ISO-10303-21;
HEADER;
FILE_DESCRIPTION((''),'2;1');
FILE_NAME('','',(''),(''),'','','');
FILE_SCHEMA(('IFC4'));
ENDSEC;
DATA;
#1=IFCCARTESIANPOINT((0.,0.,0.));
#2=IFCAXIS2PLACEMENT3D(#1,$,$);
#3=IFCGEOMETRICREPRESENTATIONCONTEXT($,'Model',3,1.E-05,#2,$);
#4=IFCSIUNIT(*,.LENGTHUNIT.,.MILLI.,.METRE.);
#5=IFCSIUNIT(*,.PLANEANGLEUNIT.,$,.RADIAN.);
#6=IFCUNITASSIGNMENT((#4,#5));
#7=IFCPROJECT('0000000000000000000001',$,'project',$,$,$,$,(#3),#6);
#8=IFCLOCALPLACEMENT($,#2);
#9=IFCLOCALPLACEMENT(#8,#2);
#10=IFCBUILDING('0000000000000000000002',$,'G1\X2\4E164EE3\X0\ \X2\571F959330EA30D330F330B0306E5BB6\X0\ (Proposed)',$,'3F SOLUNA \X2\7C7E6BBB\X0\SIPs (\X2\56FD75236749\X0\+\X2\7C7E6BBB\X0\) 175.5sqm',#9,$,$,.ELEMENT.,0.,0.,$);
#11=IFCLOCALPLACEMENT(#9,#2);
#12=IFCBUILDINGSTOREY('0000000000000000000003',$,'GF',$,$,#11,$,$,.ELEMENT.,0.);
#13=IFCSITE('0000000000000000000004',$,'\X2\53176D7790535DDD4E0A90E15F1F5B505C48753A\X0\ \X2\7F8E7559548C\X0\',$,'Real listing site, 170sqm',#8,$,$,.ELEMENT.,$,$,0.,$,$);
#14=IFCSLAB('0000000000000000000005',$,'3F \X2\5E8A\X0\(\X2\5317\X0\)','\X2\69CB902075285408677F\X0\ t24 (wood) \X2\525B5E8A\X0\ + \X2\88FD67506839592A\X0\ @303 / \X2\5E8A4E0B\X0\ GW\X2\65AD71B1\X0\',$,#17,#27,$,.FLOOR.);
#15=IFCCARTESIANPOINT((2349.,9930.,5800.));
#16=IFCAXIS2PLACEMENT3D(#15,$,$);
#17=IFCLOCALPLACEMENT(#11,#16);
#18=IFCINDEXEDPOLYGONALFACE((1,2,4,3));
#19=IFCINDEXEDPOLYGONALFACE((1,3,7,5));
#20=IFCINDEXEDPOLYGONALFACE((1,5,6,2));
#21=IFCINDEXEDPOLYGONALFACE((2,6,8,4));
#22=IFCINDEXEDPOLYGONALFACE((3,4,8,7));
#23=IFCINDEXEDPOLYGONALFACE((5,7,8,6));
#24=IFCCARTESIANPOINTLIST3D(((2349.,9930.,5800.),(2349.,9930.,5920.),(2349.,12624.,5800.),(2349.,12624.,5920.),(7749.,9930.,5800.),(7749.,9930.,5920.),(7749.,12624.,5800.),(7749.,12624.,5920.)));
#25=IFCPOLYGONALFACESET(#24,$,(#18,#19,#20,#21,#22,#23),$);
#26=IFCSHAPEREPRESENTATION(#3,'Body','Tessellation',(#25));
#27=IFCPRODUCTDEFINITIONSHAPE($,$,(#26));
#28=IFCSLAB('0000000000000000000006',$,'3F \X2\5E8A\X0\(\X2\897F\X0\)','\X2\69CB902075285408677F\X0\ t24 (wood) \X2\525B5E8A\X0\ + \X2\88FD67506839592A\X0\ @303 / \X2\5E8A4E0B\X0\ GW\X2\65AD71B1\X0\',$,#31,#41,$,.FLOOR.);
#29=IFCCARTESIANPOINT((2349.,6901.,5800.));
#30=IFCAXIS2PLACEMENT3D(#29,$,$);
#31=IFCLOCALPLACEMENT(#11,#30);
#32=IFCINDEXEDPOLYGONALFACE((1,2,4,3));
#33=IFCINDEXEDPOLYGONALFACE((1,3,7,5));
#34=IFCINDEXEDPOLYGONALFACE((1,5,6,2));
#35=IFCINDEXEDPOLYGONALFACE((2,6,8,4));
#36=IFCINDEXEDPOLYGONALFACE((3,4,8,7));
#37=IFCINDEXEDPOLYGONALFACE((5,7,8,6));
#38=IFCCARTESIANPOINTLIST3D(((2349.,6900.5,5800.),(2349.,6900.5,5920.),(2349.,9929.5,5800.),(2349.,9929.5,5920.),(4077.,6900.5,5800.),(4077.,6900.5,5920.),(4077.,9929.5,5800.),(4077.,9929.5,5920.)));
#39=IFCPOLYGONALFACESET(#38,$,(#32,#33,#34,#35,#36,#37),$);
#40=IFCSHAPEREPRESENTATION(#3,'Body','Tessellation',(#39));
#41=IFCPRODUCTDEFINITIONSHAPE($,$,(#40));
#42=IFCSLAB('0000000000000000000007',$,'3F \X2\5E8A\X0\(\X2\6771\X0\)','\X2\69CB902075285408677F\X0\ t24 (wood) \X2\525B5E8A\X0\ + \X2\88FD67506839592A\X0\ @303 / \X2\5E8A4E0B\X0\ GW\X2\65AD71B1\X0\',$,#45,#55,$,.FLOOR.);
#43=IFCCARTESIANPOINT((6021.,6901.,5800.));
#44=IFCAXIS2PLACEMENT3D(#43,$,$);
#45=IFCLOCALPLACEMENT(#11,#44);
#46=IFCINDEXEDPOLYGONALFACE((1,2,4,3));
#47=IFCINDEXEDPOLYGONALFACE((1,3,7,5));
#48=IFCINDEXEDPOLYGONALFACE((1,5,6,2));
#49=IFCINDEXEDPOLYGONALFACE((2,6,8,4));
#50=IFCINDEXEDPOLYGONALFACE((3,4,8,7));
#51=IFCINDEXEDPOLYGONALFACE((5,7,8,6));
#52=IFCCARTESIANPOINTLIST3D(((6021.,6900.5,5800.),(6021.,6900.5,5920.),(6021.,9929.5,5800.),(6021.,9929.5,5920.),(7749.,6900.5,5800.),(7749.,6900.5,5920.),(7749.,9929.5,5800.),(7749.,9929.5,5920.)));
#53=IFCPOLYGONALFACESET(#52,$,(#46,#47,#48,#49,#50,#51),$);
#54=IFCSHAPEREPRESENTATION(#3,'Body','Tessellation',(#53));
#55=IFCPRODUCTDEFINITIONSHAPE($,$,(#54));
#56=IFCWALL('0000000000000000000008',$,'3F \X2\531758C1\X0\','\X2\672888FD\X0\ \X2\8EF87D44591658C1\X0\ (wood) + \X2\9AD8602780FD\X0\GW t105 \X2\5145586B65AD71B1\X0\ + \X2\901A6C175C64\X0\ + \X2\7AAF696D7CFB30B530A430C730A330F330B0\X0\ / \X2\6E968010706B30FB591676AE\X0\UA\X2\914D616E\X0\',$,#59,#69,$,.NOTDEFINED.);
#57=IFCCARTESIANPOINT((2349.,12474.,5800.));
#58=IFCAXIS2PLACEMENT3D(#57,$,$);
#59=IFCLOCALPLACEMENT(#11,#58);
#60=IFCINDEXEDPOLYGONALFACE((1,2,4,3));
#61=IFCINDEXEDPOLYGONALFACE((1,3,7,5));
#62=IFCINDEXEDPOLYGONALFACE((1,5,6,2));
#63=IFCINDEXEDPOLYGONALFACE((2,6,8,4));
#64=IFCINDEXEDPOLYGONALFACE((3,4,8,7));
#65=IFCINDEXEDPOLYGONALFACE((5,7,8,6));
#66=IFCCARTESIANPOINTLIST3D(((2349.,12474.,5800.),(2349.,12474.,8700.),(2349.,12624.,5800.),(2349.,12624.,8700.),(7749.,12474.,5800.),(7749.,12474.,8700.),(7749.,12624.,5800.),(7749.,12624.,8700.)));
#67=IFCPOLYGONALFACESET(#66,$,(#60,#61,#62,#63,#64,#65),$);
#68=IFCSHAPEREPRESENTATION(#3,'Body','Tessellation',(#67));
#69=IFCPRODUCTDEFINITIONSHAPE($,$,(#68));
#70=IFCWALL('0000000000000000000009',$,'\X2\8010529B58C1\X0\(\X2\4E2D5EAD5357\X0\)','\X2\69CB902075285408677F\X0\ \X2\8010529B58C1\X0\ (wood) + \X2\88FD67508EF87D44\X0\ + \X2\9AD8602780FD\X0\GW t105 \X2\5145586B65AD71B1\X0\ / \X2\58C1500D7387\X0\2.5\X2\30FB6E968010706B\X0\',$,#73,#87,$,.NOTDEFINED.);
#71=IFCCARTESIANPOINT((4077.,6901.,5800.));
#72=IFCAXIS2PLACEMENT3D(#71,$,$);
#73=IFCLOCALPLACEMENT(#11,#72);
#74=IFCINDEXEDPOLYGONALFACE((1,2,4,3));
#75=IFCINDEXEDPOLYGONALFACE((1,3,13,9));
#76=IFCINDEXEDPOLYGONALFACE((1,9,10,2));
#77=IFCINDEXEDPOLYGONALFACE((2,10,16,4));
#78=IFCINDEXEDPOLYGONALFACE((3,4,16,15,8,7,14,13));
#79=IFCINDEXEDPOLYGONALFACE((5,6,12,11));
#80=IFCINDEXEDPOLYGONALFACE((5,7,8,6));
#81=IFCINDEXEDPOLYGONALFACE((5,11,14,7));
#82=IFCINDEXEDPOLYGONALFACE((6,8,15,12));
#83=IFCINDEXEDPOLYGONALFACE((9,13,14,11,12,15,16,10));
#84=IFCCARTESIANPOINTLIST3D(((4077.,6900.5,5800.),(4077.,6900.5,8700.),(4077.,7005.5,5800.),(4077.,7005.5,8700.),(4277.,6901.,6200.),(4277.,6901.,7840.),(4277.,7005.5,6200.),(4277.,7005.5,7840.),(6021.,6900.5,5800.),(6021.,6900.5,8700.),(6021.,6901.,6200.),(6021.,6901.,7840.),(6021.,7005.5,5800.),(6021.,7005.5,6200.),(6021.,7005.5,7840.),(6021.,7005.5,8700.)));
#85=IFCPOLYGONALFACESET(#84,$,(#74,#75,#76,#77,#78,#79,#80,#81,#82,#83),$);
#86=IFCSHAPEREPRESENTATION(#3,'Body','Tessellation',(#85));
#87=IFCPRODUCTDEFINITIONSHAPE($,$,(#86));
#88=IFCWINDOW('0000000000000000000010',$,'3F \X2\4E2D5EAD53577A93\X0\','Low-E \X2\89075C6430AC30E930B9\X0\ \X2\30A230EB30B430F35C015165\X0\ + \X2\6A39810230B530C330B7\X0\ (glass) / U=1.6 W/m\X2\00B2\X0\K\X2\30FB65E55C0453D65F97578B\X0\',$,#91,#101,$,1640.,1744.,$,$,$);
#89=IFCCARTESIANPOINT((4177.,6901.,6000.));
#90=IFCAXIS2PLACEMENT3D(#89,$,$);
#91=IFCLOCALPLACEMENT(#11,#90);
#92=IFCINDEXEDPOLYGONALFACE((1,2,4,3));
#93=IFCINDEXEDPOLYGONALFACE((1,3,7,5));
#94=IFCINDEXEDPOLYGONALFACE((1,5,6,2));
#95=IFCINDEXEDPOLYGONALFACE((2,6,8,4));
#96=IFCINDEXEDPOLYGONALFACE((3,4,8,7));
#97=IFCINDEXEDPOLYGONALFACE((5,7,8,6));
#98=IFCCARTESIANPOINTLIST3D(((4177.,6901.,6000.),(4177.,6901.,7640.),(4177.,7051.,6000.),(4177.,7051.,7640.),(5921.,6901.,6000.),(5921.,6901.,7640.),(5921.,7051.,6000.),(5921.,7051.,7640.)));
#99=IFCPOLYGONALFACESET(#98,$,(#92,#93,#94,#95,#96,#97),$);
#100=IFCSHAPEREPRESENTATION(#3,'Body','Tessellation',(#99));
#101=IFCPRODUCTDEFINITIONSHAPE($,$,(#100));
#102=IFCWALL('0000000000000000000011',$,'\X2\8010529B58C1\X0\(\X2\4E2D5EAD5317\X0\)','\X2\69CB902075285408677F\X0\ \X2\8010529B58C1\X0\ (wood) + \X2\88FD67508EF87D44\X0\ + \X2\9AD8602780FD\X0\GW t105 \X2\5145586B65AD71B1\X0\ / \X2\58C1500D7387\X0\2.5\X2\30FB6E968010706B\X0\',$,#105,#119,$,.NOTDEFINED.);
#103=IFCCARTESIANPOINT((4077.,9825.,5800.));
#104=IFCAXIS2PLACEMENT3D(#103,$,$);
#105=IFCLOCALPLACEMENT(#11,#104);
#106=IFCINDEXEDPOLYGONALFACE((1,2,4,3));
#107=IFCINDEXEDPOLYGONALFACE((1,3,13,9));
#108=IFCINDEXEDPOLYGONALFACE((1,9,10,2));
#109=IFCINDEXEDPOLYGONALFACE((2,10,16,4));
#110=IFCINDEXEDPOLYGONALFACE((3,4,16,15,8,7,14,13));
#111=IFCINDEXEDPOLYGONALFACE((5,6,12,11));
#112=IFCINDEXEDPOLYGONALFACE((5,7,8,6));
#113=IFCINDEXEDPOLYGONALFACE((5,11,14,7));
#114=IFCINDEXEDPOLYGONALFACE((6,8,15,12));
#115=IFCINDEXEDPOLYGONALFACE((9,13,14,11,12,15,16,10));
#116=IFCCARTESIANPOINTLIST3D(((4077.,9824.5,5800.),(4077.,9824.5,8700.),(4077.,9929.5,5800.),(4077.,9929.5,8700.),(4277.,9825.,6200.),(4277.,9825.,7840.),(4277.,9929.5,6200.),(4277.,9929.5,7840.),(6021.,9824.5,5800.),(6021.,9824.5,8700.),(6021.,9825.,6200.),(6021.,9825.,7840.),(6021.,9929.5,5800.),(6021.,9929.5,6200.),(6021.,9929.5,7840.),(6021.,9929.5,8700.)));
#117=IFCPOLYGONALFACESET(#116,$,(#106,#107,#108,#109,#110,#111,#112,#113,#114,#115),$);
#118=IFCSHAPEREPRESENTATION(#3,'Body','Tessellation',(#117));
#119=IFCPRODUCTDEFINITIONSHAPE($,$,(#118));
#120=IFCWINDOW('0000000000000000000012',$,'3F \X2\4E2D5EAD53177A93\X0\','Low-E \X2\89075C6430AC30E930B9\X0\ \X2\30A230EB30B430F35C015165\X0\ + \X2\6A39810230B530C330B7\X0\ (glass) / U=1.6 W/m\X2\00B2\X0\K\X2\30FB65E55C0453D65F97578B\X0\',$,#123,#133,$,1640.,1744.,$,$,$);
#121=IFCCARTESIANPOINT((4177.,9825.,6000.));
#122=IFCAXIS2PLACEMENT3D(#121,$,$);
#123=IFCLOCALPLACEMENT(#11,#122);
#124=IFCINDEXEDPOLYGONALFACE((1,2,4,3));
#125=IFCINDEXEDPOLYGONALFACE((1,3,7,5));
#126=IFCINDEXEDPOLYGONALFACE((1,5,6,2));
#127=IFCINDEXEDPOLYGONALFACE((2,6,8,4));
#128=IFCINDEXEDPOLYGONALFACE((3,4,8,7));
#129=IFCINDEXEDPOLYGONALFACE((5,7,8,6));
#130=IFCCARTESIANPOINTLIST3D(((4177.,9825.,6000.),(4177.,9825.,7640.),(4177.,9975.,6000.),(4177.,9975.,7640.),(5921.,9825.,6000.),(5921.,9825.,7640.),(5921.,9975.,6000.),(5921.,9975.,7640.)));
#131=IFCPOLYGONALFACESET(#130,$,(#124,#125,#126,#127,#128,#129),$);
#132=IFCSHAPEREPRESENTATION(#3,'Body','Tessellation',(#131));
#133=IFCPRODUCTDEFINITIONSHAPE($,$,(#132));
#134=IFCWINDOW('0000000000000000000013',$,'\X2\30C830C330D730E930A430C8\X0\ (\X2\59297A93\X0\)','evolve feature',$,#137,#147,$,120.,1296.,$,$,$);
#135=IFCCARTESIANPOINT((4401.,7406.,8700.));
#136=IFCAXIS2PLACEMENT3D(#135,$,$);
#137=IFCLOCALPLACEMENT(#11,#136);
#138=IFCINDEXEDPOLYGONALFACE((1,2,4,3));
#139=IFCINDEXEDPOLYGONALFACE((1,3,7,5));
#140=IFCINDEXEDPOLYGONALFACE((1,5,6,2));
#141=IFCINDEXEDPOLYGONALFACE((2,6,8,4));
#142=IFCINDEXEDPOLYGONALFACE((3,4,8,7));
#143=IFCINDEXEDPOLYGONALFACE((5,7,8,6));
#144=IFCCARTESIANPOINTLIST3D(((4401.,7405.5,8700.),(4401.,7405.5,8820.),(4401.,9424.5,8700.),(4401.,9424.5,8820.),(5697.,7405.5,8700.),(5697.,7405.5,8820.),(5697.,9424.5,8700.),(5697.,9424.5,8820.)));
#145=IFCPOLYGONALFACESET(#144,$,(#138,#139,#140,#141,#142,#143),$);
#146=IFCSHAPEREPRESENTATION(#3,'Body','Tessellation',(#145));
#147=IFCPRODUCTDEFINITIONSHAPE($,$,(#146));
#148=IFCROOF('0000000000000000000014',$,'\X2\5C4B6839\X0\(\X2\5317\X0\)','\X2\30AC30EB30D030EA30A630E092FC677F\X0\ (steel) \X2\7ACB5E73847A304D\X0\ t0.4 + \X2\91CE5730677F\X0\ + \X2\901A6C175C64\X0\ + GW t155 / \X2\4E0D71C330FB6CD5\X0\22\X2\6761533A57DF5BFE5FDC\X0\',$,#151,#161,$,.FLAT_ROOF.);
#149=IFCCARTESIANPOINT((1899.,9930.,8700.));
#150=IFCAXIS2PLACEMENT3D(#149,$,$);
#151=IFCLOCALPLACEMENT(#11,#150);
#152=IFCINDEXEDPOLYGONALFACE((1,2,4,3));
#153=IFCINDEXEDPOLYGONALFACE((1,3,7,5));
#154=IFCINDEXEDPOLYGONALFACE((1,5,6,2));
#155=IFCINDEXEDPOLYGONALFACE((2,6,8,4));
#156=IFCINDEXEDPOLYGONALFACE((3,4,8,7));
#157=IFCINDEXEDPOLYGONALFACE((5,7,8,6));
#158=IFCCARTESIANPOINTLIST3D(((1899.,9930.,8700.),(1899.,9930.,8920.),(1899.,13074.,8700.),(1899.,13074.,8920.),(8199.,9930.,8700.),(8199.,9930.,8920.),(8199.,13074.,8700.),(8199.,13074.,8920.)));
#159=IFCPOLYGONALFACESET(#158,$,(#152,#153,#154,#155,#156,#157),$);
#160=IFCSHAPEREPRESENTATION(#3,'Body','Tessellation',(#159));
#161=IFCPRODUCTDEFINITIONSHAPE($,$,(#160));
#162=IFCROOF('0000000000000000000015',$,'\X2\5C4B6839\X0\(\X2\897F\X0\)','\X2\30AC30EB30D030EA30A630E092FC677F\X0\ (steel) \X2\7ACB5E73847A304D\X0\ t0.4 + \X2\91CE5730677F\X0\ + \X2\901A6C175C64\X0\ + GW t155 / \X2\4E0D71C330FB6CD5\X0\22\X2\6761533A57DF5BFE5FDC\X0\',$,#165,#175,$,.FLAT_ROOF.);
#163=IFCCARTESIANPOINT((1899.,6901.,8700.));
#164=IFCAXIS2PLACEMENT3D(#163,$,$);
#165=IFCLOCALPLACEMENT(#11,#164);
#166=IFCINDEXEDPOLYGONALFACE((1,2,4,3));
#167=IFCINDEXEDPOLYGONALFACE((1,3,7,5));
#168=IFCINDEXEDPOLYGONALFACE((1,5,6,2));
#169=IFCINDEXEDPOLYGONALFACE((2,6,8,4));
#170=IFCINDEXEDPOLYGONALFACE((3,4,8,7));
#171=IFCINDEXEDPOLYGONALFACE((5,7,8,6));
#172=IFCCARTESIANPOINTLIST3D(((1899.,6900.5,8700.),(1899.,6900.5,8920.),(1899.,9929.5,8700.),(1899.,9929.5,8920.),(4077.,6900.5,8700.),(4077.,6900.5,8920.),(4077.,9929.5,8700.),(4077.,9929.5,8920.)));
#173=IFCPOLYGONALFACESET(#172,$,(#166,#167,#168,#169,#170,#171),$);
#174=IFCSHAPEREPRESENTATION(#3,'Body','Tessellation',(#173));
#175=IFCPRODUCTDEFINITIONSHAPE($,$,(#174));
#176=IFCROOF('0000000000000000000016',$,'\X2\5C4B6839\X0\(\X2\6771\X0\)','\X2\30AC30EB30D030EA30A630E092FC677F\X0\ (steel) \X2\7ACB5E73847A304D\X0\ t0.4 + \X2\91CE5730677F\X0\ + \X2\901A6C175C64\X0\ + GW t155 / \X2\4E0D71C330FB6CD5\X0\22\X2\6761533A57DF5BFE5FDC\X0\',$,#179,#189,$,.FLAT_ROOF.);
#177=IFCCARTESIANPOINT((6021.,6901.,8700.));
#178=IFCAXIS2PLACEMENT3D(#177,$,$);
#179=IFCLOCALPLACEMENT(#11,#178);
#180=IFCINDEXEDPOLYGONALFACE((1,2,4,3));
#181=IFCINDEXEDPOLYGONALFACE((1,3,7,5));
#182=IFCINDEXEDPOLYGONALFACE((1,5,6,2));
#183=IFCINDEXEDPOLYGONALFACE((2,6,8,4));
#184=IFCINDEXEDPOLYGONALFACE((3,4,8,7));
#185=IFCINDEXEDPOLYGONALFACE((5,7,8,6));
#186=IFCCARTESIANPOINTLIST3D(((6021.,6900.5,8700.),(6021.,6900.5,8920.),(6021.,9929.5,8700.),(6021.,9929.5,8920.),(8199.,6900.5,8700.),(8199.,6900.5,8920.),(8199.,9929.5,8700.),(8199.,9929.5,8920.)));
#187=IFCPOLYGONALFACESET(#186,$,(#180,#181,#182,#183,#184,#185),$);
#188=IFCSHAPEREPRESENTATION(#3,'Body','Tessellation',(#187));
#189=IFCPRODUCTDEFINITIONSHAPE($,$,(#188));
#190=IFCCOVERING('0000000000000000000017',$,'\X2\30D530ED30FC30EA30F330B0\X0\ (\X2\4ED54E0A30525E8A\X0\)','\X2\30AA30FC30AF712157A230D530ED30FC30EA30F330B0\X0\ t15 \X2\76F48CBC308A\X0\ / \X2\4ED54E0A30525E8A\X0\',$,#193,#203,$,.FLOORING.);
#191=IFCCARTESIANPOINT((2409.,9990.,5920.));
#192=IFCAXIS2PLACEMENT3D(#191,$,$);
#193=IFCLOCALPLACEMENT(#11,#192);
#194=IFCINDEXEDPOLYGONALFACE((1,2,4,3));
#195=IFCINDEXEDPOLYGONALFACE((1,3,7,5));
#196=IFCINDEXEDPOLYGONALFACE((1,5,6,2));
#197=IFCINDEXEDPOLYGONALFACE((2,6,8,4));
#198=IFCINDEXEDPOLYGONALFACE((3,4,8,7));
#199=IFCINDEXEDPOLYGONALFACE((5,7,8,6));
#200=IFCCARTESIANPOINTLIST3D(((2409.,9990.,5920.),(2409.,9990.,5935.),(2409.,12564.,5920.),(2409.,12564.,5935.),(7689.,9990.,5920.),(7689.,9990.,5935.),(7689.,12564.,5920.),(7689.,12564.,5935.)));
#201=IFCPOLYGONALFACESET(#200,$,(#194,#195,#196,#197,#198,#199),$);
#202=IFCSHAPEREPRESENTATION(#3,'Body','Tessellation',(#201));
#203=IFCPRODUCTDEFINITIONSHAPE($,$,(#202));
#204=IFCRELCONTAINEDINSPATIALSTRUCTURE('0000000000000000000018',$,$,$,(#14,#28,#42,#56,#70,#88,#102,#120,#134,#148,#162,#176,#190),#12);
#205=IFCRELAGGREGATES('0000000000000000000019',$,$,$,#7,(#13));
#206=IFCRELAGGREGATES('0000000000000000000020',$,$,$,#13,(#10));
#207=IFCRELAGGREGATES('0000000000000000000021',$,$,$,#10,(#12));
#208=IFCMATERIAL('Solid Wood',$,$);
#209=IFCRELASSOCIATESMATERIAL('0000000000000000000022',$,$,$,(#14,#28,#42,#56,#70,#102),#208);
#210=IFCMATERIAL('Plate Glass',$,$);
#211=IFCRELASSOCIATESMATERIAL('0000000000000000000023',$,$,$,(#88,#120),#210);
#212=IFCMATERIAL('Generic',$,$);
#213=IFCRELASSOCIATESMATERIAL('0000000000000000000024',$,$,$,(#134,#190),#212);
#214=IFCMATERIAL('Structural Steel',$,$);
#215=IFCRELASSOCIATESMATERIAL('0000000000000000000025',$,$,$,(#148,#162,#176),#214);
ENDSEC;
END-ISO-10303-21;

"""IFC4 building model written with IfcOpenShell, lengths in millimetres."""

from ifc_helpers import new_model, si_unit, frame, frame_2d, origin, place, context, project, spatial, rectangle, extrude, material, element, fill, save


model = new_model("IFC4")

# Units and contexts
model_context = context("Model", 3, precision=1e-05, world=origin())
ifc_project = project(units=[si_unit("LENGTHUNIT", "METRE", prefix="MILLI"), si_unit("PLANEANGLEUNIT", "RADIAN")], contexts=[model_context])

# Site, building, storey
site_placement = place(None, origin())
site = spatial("IfcSite", under=ifc_project, at=site_placement, Name="北海道川上郡弟子屈町 美留和", ObjectType="Real listing site, 170sqm", CompositionType="ELEMENT", RefElevation=0.0)
building_placement = place(site_placement, origin())
building = spatial("IfcBuilding", under=site, at=building_placement, Name="G1世代 土間リビングの家 (Proposed)", ObjectType="3F SOLUNA 籾殻SIPs (国産杉+籾殻) 175.5sqm", CompositionType="ELEMENT", ElevationOfRefHeight=0.0, ElevationOfTerrain=0.0)
storey_placement = place(building_placement, origin())
storey = spatial("IfcBuildingStorey", under=building, at=storey_placement, Name="GF", CompositionType="ELEMENT", Elevation=0.0)

# Slabs
ifc_material_1 = material(Name="Solid Wood")
slab_1_placement = place(storey_placement, frame((2349.0, 9930.0, 5800.0)))
element("IfcSlab", 1, at=slab_1_placement, inside=storey, material=ifc_material_1, Name="3F 床(北)", Description="構造用合板 t24 (wood) 剛床 + 製材根太 @303 / 床下 GW断熱", PredefinedType="FLOOR", context=model_context, shape_type="SweptSolid", body=[
    extrude(rectangle(XDim=5400.0, YDim=2694.0, at=frame_2d((2700.0, 1347.0))), frame((2349.0, 9930.0, 5800.0)), (0.0, 0.0, 1.0), 120.0),
])
slab_2_placement = place(storey_placement, frame((2349.0, 6901.0, 5800.0)))
element("IfcSlab", 2, at=slab_2_placement, inside=storey, material=ifc_material_1, Name="3F 床(西)", Description="構造用合板 t24 (wood) 剛床 + 製材根太 @303 / 床下 GW断熱", PredefinedType="FLOOR", context=model_context, shape_type="SweptSolid", body=[
    extrude(rectangle(XDim=1728.0, YDim=3029.0, at=frame_2d((864.0, 1514.0))), frame((2349.0, 6901.0, 5800.0)), (0.0, 0.0, 1.0), 120.0),
])
slab_3_placement = place(storey_placement, frame((6021.0, 6901.0, 5800.0)))
element("IfcSlab", 3, at=slab_3_placement, inside=storey, material=ifc_material_1, Name="3F 床(東)", Description="構造用合板 t24 (wood) 剛床 + 製材根太 @303 / 床下 GW断熱", PredefinedType="FLOOR", context=model_context, shape_type="SweptSolid", body=[
    extrude(rectangle(XDim=1728.0, YDim=3029.0, at=frame_2d((864.0, 1514.0))), frame((6021.0, 6901.0, 5800.0)), (0.0, 0.0, 1.0), 120.0),
])

# Wall
wall_1_placement = place(storey_placement, frame((2349.0, 12474.0, 5800.0)))
element("IfcWall", 4, at=wall_1_placement, inside=storey, material=ifc_material_1, Name="3F 北壁", Description="木製 軸組外壁 (wood) + 高性能GW t105 充填断熱 + 通気層 + 窯業系サイディング / 準耐火・外皮UA配慮", PredefinedType="NOTDEFINED", context=model_context, shape_type="SweptSolid", body=[
    extrude(rectangle(XDim=5400.0, YDim=150.0, at=frame_2d((2700.0, 75.0))), frame((2349.0, 12474.0, 5800.0)), (0.0, 0.0, 1.0), 2900.0),
])

# Walls, openings, windows
wall_2_placement = place(storey_placement, frame((4077.0, 6901.0, 5800.0)))
wall_2 = element("IfcWall", 5, at=wall_2_placement, inside=storey, material=ifc_material_1, Name="耐力壁(中庭南)", Description="構造用合板 耐力壁 (wood) + 製材軸組 + 高性能GW t105 充填断熱 / 壁倍率2.5・準耐火", PredefinedType="NOTDEFINED", context=model_context, shape_type="SweptSolid", body=[
    extrude(rectangle(XDim=1944.0, YDim=105.0, at=frame_2d((972.0, 52.0))), frame((4077.0, 6901.0, 5800.0)), (0.0, 0.0, 1.0), 2900.0),
])
opening_1_placement = place(storey_placement, frame((4177.0, 6901.0, 6000.0)))
opening_1 = element("IfcOpeningElement", 6, at=opening_1_placement, cuts=wall_2, PredefinedType="NOTDEFINED", context=model_context, shape_type="SweptSolid", body=[
    extrude(rectangle(XDim=1744.0, YDim=150.0, at=frame_2d((872.0, 75.0))), frame((4177.0, 6901.0, 6000.0)), (0.0, 0.0, 1.0), 1640.0),
])
ifc_material_2 = material(Name="Plate Glass")
window_1_placement = place(storey_placement, frame((4177.0, 6901.0, 6000.0)))
window_1 = element("IfcWindow", 7, at=window_1_placement, inside=storey, material=ifc_material_2, Name="3F 中庭南窓", Description="Low-E 複層ガラス アルゴン封入 + 樹脂サッシ (glass) / U=1.6 W/m²K・日射取得型", OverallHeight=1640.0, OverallWidth=1744.0, context=model_context, shape_type="SweptSolid", body=[
    extrude(rectangle(XDim=1744.0, YDim=150.0, at=frame_2d((872.0, 75.0))), frame((4177.0, 6901.0, 6000.0)), (0.0, 0.0, 1.0), 1640.0),
])
fill(opening_1, window_1)
wall_3_placement = place(storey_placement, frame((4077.0, 9825.0, 5800.0)))
wall_3 = element("IfcWall", 8, at=wall_3_placement, inside=storey, material=ifc_material_1, Name="耐力壁(中庭北)", Description="構造用合板 耐力壁 (wood) + 製材軸組 + 高性能GW t105 充填断熱 / 壁倍率2.5・準耐火", PredefinedType="NOTDEFINED", context=model_context, shape_type="SweptSolid", body=[
    extrude(rectangle(XDim=1944.0, YDim=105.0, at=frame_2d((972.0, 52.0))), frame((4077.0, 9825.0, 5800.0)), (0.0, 0.0, 1.0), 2900.0),
])
opening_2_placement = place(storey_placement, frame((4177.0, 9825.0, 6000.0)))
opening_2 = element("IfcOpeningElement", 9, at=opening_2_placement, cuts=wall_3, PredefinedType="NOTDEFINED", context=model_context, shape_type="SweptSolid", body=[
    extrude(rectangle(XDim=1744.0, YDim=150.0, at=frame_2d((872.0, 75.0))), frame((4177.0, 9825.0, 6000.0)), (0.0, 0.0, 1.0), 1640.0),
])
window_2_placement = place(storey_placement, frame((4177.0, 9825.0, 6000.0)))
window_2 = element("IfcWindow", 10, at=window_2_placement, inside=storey, material=ifc_material_2, Name="3F 中庭北窓", Description="Low-E 複層ガラス アルゴン封入 + 樹脂サッシ (glass) / U=1.6 W/m²K・日射取得型", OverallHeight=1640.0, OverallWidth=1744.0, context=model_context, shape_type="SweptSolid", body=[
    extrude(rectangle(XDim=1744.0, YDim=150.0, at=frame_2d((872.0, 75.0))), frame((4177.0, 9825.0, 6000.0)), (0.0, 0.0, 1.0), 1640.0),
])
fill(opening_2, window_2)

# Window
ifc_material_3 = material(Name="Generic")
window_3_placement = place(storey_placement, frame((4401.0, 7406.0, 8700.0)))
element("IfcWindow", 11, at=window_3_placement, inside=storey, material=ifc_material_3, Name="トップライト (天窓)", Description="evolve feature", OverallHeight=120.0, OverallWidth=1296.0, context=model_context, shape_type="SweptSolid", body=[
    extrude(rectangle(XDim=1296.0, YDim=2019.0, at=frame_2d((648.0, 1009.0))), frame((4401.0, 7406.0, 8700.0)), (0.0, 0.0, 1.0), 120.0),
])

# Roofs
ifc_material_4 = material(Name="Structural Steel")
for number, where, name in (
    (12, (1899.0, 9930.0, 8700.0), "屋根(北)"),
):
    element("IfcRoof", number, at=place(storey_placement, frame(where)), inside=storey, material=ifc_material_4, Name=name, Description="ガルバリウム鋼板 (steel) 立平葺き t0.4 + 野地板 + 通気層 + GW t155 / 不燃・法22条区域対応", PredefinedType="FLAT_ROOF", context=model_context, shape_type="SweptSolid", body=[
        extrude(rectangle(XDim=6300.0, YDim=3144.0, at=frame_2d((3150.0, 1572.0))), frame((1899.0, 9930.0, 8700.0)), (0.0, 0.0, 1.0), 220.0),
    ])
roof_1_placement = place(storey_placement, frame((1899.0, 6901.0, 8700.0)))
element("IfcRoof", 13, at=roof_1_placement, inside=storey, material=ifc_material_4, Name="屋根(西)", Description="ガルバリウム鋼板 (steel) 立平葺き t0.4 + 野地板 + 通気層 + GW t155 / 不燃・法22条区域対応", PredefinedType="FLAT_ROOF", context=model_context, shape_type="SweptSolid", body=[
    extrude(rectangle(XDim=2178.0, YDim=3029.0, at=frame_2d((1089.0, 1514.0))), frame((1899.0, 6901.0, 8700.0)), (0.0, 0.0, 1.0), 220.0),
])
roof_2_placement = place(storey_placement, frame((6021.0, 6901.0, 8700.0)))
element("IfcRoof", 14, at=roof_2_placement, inside=storey, material=ifc_material_4, Name="屋根(東)", Description="ガルバリウム鋼板 (steel) 立平葺き t0.4 + 野地板 + 通気層 + GW t155 / 不燃・法22条区域対応", PredefinedType="FLAT_ROOF", context=model_context, shape_type="SweptSolid", body=[
    extrude(rectangle(XDim=2178.0, YDim=3029.0, at=frame_2d((1089.0, 1514.0))), frame((6021.0, 6901.0, 8700.0)), (0.0, 0.0, 1.0), 220.0),
])

# Covering
covering_1_placement = place(storey_placement, frame((2409.0, 9990.0, 5920.0)))
element("IfcCovering", 15, at=covering_1_placement, inside=storey, material=ifc_material_3, Name="フローリング (仕上げ床)", Description="オーク無垢フローリング t15 直貼り / 仕上げ床", PredefinedType="FLOORING", context=model_context, shape_type="SweptSolid", body=[
    extrude(rectangle(XDim=5280.0, YDim=2574.0, at=frame_2d((2640.0, 1287.0))), frame((2409.0, 9990.0, 5920.0)), (0.0, 0.0, 1.0), 15.0),
])

save(model, "model.ifc")
